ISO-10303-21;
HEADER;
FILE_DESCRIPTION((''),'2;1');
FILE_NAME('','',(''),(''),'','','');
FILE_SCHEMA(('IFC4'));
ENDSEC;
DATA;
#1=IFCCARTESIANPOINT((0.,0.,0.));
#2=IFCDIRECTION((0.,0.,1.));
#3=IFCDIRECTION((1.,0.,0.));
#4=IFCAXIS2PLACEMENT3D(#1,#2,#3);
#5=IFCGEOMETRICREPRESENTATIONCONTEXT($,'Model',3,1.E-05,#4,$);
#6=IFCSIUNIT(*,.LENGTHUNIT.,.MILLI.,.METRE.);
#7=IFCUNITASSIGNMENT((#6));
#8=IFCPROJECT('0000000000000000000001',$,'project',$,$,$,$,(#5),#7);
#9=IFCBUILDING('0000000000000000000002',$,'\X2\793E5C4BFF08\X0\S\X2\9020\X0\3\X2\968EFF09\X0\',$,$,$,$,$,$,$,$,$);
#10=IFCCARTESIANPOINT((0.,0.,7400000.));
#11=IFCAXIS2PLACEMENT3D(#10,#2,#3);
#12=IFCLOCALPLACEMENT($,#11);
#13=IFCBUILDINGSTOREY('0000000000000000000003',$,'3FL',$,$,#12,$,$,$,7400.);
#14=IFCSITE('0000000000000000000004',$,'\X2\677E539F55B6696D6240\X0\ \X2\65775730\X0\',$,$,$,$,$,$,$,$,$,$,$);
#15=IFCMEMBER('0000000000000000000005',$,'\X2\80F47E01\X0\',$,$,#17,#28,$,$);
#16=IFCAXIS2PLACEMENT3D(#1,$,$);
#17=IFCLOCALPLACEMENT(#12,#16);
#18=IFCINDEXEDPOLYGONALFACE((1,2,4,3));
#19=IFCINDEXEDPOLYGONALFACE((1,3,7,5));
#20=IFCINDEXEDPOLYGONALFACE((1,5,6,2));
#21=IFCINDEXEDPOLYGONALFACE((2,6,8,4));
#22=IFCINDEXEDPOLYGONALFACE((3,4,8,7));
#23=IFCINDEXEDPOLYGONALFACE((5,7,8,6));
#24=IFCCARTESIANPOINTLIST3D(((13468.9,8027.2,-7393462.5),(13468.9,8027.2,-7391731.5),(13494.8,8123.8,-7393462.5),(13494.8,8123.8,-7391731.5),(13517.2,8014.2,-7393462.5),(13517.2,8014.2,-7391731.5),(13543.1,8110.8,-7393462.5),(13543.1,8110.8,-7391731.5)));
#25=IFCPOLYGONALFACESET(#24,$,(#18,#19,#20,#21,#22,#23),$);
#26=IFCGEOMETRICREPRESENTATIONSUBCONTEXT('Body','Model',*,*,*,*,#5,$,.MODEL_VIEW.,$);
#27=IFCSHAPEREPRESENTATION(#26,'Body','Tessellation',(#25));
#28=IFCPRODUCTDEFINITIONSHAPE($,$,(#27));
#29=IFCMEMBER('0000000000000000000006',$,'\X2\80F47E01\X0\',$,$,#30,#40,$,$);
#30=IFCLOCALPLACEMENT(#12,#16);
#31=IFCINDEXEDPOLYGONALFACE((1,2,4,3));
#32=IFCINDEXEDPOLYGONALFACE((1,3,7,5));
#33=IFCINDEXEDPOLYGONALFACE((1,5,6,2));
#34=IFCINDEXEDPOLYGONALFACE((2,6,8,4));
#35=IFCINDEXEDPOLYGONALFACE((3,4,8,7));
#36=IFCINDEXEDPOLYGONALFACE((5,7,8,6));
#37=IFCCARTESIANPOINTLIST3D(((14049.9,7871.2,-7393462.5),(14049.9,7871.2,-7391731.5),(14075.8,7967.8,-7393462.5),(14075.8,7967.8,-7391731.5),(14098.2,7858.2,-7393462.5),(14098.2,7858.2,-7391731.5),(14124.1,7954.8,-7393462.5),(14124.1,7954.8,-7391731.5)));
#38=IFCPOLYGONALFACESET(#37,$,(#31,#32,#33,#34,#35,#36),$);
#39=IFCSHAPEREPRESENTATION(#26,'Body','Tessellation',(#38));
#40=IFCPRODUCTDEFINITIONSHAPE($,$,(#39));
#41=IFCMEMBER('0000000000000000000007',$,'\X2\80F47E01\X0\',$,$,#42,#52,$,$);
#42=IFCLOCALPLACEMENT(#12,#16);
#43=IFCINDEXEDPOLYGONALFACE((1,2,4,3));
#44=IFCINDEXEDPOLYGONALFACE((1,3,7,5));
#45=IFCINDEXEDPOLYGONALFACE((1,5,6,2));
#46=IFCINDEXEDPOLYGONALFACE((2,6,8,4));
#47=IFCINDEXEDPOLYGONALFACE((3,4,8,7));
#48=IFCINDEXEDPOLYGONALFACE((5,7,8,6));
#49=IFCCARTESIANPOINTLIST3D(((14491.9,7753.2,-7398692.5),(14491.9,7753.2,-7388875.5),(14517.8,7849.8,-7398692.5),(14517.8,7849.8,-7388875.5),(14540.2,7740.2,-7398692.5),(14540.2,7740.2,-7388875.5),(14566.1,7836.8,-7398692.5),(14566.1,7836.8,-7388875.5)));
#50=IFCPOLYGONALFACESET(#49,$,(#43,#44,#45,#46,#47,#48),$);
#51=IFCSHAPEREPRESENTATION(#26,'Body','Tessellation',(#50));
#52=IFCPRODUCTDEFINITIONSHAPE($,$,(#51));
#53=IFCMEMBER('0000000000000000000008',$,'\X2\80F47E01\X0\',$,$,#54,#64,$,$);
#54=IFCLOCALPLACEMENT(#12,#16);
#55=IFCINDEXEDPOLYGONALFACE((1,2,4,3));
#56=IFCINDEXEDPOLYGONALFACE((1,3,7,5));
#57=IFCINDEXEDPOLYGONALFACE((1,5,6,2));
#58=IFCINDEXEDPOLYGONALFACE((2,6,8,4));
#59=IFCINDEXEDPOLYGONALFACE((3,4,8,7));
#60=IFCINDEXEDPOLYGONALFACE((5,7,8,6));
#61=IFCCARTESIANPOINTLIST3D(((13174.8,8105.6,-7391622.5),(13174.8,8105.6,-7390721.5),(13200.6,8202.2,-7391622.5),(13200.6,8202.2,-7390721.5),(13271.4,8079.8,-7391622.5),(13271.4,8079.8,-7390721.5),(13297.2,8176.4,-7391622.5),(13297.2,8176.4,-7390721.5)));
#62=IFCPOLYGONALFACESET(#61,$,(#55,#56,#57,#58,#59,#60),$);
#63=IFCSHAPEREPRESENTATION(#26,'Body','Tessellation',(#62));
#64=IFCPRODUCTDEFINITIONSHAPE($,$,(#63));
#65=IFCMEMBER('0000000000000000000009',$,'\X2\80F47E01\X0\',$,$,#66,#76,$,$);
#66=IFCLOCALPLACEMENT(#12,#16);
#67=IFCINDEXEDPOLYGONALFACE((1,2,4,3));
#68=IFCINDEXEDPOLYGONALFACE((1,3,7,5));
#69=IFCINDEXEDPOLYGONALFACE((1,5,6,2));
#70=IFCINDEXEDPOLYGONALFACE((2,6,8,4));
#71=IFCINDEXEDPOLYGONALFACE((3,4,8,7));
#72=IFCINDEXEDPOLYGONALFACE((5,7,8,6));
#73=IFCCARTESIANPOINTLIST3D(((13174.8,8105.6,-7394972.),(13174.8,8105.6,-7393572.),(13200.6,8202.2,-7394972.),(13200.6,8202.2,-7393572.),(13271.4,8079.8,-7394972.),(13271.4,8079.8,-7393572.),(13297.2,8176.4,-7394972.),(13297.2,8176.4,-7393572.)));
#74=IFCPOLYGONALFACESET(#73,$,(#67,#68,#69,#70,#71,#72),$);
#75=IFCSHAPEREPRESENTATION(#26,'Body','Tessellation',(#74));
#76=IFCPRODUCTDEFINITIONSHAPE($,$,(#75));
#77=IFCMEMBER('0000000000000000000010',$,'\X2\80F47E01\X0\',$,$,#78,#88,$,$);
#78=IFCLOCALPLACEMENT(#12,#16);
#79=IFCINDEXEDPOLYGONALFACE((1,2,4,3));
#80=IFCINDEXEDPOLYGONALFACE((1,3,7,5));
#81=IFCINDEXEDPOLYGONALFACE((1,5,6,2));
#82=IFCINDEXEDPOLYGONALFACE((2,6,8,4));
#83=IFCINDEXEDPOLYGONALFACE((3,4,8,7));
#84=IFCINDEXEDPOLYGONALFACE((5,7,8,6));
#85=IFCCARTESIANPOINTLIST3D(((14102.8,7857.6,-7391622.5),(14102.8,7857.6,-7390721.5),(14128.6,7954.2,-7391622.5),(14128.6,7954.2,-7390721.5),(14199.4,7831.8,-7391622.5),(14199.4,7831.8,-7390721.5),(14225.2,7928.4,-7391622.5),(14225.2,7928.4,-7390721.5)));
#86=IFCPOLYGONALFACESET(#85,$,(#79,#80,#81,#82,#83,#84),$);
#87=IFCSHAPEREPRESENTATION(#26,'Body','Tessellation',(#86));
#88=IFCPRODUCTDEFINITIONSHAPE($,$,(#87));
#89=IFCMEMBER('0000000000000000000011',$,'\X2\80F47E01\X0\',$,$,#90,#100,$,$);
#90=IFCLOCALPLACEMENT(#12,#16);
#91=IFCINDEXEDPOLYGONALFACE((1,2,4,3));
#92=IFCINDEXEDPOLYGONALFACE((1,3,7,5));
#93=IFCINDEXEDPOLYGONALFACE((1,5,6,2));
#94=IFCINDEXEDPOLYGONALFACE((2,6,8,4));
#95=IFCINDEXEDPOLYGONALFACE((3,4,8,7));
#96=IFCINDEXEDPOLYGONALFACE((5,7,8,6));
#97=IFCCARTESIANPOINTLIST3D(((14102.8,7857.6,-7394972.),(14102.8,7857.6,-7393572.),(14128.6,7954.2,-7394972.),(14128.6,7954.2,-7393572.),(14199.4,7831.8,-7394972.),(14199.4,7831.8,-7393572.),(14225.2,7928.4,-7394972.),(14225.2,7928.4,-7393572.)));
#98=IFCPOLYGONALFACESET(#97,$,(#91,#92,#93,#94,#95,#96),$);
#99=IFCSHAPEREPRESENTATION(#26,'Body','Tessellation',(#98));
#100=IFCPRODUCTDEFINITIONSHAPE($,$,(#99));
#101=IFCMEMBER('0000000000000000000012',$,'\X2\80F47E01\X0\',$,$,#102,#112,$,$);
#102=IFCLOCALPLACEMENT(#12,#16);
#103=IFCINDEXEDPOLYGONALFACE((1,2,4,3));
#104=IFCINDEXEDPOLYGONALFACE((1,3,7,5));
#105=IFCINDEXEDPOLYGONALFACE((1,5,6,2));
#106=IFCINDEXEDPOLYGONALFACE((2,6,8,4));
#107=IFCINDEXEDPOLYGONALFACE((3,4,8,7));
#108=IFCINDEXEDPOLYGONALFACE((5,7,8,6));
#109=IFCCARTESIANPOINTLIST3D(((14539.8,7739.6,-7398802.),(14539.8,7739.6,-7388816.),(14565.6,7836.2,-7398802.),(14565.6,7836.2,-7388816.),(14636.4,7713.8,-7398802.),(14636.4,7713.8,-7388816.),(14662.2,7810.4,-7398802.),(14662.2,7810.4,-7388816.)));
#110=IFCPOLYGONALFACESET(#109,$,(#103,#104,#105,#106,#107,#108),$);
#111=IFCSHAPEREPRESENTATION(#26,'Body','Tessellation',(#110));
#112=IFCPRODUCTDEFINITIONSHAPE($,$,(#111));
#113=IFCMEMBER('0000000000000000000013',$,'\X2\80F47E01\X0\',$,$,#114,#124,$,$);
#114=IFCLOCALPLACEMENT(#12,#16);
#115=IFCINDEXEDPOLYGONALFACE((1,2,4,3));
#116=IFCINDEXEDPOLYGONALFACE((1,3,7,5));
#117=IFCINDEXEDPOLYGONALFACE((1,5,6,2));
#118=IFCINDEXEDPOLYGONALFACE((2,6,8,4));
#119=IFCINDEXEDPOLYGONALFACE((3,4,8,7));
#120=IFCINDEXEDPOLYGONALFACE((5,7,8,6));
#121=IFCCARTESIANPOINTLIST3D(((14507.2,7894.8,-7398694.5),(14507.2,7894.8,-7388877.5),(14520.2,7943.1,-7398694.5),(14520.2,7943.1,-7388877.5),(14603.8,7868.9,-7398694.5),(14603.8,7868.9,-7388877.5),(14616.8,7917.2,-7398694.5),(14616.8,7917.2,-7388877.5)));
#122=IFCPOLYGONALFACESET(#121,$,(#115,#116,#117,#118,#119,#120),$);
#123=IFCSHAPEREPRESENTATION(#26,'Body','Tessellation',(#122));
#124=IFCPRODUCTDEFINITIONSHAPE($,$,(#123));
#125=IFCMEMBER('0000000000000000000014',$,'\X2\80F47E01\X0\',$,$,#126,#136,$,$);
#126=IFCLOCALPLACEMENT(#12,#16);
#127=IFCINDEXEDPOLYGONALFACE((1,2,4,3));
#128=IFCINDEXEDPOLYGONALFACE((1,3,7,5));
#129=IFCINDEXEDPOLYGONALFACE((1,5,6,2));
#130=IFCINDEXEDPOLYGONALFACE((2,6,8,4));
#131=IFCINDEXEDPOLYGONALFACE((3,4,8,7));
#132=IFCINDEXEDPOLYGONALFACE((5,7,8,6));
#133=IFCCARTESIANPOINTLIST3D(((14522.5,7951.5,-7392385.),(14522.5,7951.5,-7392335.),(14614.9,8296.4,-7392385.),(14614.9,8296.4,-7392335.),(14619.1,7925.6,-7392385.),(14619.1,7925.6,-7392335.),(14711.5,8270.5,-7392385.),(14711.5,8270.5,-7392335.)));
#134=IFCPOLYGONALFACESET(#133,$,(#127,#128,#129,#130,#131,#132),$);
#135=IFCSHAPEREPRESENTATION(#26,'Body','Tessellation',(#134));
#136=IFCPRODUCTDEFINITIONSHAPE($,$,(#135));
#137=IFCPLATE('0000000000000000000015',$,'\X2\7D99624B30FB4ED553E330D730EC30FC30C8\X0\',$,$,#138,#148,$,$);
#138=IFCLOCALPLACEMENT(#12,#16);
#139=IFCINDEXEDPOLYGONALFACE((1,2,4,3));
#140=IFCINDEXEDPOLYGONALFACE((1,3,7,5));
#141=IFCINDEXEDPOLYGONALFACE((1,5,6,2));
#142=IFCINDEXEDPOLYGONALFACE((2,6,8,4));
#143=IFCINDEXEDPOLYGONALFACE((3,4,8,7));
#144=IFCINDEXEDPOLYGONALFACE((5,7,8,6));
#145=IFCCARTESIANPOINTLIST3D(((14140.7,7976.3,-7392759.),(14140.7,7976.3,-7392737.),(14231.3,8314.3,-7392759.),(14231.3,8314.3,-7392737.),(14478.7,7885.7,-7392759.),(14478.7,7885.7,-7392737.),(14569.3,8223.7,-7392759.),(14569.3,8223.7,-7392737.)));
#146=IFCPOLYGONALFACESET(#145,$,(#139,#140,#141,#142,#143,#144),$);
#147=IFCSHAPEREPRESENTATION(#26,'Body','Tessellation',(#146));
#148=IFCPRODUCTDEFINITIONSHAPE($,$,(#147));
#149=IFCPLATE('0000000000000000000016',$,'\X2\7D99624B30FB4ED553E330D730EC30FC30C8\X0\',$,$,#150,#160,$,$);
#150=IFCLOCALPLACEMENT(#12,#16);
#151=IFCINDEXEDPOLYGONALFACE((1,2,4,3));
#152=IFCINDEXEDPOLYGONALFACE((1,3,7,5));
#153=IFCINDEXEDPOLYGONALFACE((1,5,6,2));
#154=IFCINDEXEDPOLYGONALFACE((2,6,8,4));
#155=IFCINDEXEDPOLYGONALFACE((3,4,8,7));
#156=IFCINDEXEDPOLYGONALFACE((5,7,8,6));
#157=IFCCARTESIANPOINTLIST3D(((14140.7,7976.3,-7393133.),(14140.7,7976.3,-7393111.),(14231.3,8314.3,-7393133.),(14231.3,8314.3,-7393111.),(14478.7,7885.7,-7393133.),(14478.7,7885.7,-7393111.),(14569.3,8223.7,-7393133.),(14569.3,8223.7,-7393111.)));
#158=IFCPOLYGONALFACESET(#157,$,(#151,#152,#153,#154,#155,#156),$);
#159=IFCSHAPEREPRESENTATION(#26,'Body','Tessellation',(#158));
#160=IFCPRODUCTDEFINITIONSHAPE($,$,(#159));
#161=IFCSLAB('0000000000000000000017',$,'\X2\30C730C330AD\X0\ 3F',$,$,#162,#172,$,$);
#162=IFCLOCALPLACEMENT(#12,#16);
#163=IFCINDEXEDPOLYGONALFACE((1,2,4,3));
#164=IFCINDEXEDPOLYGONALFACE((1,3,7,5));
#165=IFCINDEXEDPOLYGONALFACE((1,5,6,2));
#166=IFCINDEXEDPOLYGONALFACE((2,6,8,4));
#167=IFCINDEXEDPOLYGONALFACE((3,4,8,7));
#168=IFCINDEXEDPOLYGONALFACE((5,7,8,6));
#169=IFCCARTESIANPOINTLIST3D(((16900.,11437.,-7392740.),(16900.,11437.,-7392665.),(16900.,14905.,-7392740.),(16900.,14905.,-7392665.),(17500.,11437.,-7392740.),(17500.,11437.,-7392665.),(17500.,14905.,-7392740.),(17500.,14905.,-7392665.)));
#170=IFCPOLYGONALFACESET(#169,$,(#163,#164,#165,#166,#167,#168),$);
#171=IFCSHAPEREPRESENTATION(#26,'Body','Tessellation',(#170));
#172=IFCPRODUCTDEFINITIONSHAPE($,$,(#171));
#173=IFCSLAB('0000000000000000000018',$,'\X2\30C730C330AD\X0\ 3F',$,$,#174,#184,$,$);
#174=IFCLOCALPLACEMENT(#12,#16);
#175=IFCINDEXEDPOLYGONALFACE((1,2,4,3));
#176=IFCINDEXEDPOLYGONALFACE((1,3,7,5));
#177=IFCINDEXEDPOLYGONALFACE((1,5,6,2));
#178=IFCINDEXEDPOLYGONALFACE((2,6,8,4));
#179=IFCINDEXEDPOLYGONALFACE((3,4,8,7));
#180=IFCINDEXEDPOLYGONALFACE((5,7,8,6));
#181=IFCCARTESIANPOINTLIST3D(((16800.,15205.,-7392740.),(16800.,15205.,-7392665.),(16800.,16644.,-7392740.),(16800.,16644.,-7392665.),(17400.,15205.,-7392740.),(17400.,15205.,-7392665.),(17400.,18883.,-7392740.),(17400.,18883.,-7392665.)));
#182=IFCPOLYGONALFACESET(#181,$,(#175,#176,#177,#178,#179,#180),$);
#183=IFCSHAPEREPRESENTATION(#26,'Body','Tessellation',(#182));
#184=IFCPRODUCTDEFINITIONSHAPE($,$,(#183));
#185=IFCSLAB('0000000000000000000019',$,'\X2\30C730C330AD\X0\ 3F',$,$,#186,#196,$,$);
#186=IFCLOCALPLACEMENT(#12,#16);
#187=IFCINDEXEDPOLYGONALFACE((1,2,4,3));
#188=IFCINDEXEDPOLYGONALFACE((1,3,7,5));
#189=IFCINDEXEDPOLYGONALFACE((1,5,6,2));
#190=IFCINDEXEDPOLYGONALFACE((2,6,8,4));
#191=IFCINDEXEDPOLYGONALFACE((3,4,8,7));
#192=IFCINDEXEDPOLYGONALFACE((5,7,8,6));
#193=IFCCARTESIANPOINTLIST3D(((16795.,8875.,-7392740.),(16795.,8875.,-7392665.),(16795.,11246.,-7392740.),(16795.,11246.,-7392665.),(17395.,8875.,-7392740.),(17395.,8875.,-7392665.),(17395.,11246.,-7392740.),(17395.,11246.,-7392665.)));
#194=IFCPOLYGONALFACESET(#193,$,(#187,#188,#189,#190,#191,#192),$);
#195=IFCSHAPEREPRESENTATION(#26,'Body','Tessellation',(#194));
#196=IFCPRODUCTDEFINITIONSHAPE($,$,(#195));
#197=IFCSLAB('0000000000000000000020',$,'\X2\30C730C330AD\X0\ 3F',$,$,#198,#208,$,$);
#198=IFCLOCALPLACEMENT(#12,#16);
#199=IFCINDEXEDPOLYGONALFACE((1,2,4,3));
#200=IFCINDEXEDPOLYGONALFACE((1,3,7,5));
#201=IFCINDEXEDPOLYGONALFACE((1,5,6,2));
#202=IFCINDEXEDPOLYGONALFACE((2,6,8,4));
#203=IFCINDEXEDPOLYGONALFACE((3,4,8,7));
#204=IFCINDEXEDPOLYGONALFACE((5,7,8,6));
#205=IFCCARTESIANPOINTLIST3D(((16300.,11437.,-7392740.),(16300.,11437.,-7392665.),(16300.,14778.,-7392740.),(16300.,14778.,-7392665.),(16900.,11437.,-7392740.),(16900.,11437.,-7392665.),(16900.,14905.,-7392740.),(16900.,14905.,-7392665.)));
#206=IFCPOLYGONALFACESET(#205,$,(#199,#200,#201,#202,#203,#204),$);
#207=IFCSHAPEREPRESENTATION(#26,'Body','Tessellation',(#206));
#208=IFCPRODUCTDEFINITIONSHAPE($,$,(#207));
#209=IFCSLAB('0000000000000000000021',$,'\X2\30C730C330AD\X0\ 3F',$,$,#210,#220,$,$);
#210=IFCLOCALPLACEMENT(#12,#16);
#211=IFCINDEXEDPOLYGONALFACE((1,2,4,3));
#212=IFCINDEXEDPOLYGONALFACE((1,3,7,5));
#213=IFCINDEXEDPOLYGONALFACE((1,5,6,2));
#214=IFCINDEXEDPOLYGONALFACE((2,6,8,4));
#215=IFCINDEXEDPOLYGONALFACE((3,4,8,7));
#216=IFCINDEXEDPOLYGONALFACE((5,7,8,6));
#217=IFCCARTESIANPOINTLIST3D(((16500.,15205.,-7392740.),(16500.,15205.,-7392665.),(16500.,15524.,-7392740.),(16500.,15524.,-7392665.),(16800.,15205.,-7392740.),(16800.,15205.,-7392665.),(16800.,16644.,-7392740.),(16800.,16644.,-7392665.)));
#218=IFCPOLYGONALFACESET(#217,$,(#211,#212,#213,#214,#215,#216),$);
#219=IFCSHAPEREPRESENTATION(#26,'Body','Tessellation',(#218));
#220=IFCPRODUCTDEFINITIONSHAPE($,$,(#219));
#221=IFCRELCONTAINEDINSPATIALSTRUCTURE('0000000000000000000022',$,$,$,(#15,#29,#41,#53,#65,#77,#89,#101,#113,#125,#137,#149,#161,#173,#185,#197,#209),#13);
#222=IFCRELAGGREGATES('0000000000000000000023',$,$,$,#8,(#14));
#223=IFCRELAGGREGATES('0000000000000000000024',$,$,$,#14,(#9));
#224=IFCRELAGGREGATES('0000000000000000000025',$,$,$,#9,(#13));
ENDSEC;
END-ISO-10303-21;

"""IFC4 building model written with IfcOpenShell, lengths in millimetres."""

from ifc_helpers import new_model, si_unit, frame, origin, origin_with_axes, place, context, subcontext, project, spatial, polyline, rectangle, outline, extrude, element, save


model = new_model("IFC4")

# Units and contexts
model_context = context("Model", 3, precision=1e-05, world=origin_with_axes())
body_context = subcontext(model_context, "Body", "Model", "MODEL_VIEW")
ifc_project = project(units=[si_unit("LENGTHUNIT", "METRE", prefix="MILLI")], contexts=[model_context])

# Site, building, storey
site = spatial("IfcSite", under=ifc_project, Name="松原営業所 敷地")
building = spatial("IfcBuilding", under=site, Name="社屋（S造3階）")
storey_placement = place(None, frame((0.0, 0.0, 7400000.0), z_axis=(0.0, 0.0, 1.0), x_axis=(1.0, 0.0, 0.0)))
storey = spatial("IfcBuildingStorey", under=building, at=storey_placement, Name="3FL", Elevation=7400.0)

# Members
for number, where, z_axis, x_axis, name in (
    (1, (13481.9, 8075.5, -7392597.0), (0.965926, -0.258819, 0.0), (0.258819, 0.965926, 0.0), "胴縁"),
    (2, (14062.9, 7919.5, -7392597.0), (0.965926, -0.258819, 0.0), (0.258819, 0.965926, 0.0), "胴縁"),
):
    element("IfcMember", number, at=place(storey_placement, frame(where, z_axis=z_axis, x_axis=x_axis)), inside=storey, Name=name, context=body_context, shape_type="SweptSolid", body=[
        extrude(rectangle(XDim=100.0, YDim=1731.0), origin(), (0.0, 0.0, 1.0), 50.0),
    ])
member_1_placement = place(storey_placement, frame((14504.9, 7801.5, -7393784.0), z_axis=(0.965926, -0.258819, 0.0), x_axis=(0.258819, 0.965926, 0.0)))
element("IfcMember", 3, at=member_1_placement, inside=storey, Name="胴縁", context=body_context, shape_type="SweptSolid", body=[
    extrude(rectangle(XDim=100.0, YDim=9817.0), origin(), (0.0, 0.0, 1.0), 50.0),
])
member_2_placement = place(storey_placement, frame((13187.7, 8153.9, -7391172.0), z_axis=(0.965926, -0.258819, 0.0), x_axis=(0.258819, 0.965926, 0.0)))
element("IfcMember", 4, at=member_2_placement, inside=storey, Name="胴縁", context=body_context, shape_type="SweptSolid", body=[
    extrude(rectangle(XDim=100.0, YDim=901.0), origin(), (0.0, 0.0, 1.0), 100.0),
])
member_3_placement = place(storey_placement, frame((13187.7, 8153.9, -7394272.0), z_axis=(0.965926, -0.258819, 0.0), x_axis=(0.258819, 0.965926, 0.0)))
element("IfcMember", 5, at=member_3_placement, inside=storey, Name="胴縁", context=body_context, shape_type="SweptSolid", body=[
    extrude(rectangle(XDim=100.0, YDim=1400.0), origin(), (0.0, 0.0, 1.0), 100.0),
])
member_4_placement = place(storey_placement, frame((14115.7, 7905.9, -7391172.0), z_axis=(0.965926, -0.258819, 0.0), x_axis=(0.258819, 0.965926, 0.0)))
element("IfcMember", 6, at=member_4_placement, inside=storey, Name="胴縁", context=body_context, shape_type="SweptSolid", body=[
    extrude(rectangle(XDim=100.0, YDim=901.0), origin(), (0.0, 0.0, 1.0), 100.0),
])
member_5_placement = place(storey_placement, frame((14115.7, 7905.9, -7394272.0), z_axis=(0.965926, -0.258819, 0.0), x_axis=(0.258819, 0.965926, 0.0)))
element("IfcMember", 7, at=member_5_placement, inside=storey, Name="胴縁", context=body_context, shape_type="SweptSolid", body=[
    extrude(rectangle(XDim=100.0, YDim=1400.0), origin(), (0.0, 0.0, 1.0), 100.0),
])
member_6_placement = place(storey_placement, frame((14552.7, 7787.9, -7393809.0), z_axis=(0.965926, -0.258819, 0.0), x_axis=(0.258819, 0.965926, 0.0)))
element("IfcMember", 8, at=member_6_placement, inside=storey, Name="胴縁", context=body_context, shape_type="SweptSolid", body=[
    extrude(rectangle(XDim=100.0, YDim=9986.0), origin(), (0.0, 0.0, 1.0), 100.0),
])
member_7_placement = place(storey_placement, frame((14555.5, 7881.9, -7393786.0), z_axis=(0.258819, 0.965926, 0.0), x_axis=(-0.965926, 0.258819, 0.0)))
element("IfcMember", 9, at=member_7_placement, inside=storey, Name="胴縁", context=body_context, shape_type="SweptSolid", body=[
    extrude(rectangle(XDim=100.0, YDim=9817.0), origin(), (0.0, 0.0, 1.0), 50.0),
])
member_8_placement = place(storey_placement, frame((14570.8, 7938.6, -7392360.0), z_axis=(0.258819, 0.965926, 0.0), x_axis=(-0.965926, 0.258819, 0.0)))
element("IfcMember", 10, at=member_8_placement, inside=storey, Name="胴縁", context=body_context, shape_type="SweptSolid", body=[
    extrude(rectangle(XDim=100.0, YDim=50.0), origin(), (0.0, 0.0, 1.0), 357.0),
])

# Plates
for number, where, z_axis, x_axis, name in (
    (11, (14186.0, 8145.3, -7392748.0), (0.965926, -0.258819, 0.0), (0.258819, 0.965926, 0.0), "継手・仕口プレート"),
    (12, (14186.0, 8145.3, -7393122.0), (0.965926, -0.258819, 0.0), (0.258819, 0.965926, 0.0), "継手・仕口プレート"),
):
    element("IfcPlate", number, at=place(storey_placement, frame(where, z_axis=z_axis, x_axis=x_axis)), inside=storey, Name=name, context=body_context, shape_type="SweptSolid", body=[
        extrude(rectangle(XDim=350.0, YDim=22.0), origin(), (0.0, 0.0, 1.0), 350.0),
    ])

# Slabs
slab_1_placement = place(storey_placement, frame((0.0, 0.0, -7392740.0), z_axis=(0.0, 0.0, 1.0), x_axis=(1.0, 0.0, 0.0)))
element("IfcSlab", 13, at=slab_1_placement, inside=storey, Name="デッキ 3F", context=body_context, shape_type="SweptSolid", body=[
    extrude(outline(polyline([(17500.0, 11437.0), (17500.0, 14905.0), (16900.0, 14905.0), (16900.0, 11437.0), (17500.0, 11437.0)])), origin(), (0.0, 0.0, 1.0), 75.0),
])
slab_2_placement = place(storey_placement, frame((0.0, 0.0, -7392740.0), z_axis=(0.0, 0.0, 1.0), x_axis=(1.0, 0.0, 0.0)))
element("IfcSlab", 14, at=slab_2_placement, inside=storey, Name="デッキ 3F", context=body_context, shape_type="SweptSolid", body=[
    extrude(outline(polyline([(17400.0, 15205.0), (17400.0, 18883.0), (16800.0, 16644.0), (16800.0, 15205.0), (17400.0, 15205.0)])), origin(), (0.0, 0.0, 1.0), 75.0),
])
slab_3_placement = place(storey_placement, frame((0.0, 0.0, -7392740.0), z_axis=(0.0, 0.0, 1.0), x_axis=(1.0, 0.0, 0.0)))
element("IfcSlab", 15, at=slab_3_placement, inside=storey, Name="デッキ 3F", context=body_context, shape_type="SweptSolid", body=[
    extrude(outline(polyline([(17395.0, 8875.0), (17395.0, 11246.0), (16795.0, 11246.0), (16795.0, 8875.0), (17395.0, 8875.0)])), origin(), (0.0, 0.0, 1.0), 75.0),
])
slab_4_placement = place(storey_placement, frame((0.0, 0.0, -7392740.0), z_axis=(0.0, 0.0, 1.0), x_axis=(1.0, 0.0, 0.0)))
element("IfcSlab", 16, at=slab_4_placement, inside=storey, Name="デッキ 3F", context=body_context, shape_type="SweptSolid", body=[
    extrude(outline(polyline([(16900.0, 11437.0), (16900.0, 14905.0), (16300.0, 14778.0), (16300.0, 11437.0), (16900.0, 11437.0)])), origin(), (0.0, 0.0, 1.0), 75.0),
])
slab_5_placement = place(storey_placement, frame((0.0, 0.0, -7392740.0), z_axis=(0.0, 0.0, 1.0), x_axis=(1.0, 0.0, 0.0)))
element("IfcSlab", 17, at=slab_5_placement, inside=storey, Name="デッキ 3F", context=body_context, shape_type="SweptSolid", body=[
    extrude(outline(polyline([(16800.0, 15205.0), (16800.0, 16644.0), (16500.0, 15524.0), (16500.0, 15205.0), (16800.0, 15205.0)])), origin(), (0.0, 0.0, 1.0), 75.0),
])

save(model, "model.ifc")
